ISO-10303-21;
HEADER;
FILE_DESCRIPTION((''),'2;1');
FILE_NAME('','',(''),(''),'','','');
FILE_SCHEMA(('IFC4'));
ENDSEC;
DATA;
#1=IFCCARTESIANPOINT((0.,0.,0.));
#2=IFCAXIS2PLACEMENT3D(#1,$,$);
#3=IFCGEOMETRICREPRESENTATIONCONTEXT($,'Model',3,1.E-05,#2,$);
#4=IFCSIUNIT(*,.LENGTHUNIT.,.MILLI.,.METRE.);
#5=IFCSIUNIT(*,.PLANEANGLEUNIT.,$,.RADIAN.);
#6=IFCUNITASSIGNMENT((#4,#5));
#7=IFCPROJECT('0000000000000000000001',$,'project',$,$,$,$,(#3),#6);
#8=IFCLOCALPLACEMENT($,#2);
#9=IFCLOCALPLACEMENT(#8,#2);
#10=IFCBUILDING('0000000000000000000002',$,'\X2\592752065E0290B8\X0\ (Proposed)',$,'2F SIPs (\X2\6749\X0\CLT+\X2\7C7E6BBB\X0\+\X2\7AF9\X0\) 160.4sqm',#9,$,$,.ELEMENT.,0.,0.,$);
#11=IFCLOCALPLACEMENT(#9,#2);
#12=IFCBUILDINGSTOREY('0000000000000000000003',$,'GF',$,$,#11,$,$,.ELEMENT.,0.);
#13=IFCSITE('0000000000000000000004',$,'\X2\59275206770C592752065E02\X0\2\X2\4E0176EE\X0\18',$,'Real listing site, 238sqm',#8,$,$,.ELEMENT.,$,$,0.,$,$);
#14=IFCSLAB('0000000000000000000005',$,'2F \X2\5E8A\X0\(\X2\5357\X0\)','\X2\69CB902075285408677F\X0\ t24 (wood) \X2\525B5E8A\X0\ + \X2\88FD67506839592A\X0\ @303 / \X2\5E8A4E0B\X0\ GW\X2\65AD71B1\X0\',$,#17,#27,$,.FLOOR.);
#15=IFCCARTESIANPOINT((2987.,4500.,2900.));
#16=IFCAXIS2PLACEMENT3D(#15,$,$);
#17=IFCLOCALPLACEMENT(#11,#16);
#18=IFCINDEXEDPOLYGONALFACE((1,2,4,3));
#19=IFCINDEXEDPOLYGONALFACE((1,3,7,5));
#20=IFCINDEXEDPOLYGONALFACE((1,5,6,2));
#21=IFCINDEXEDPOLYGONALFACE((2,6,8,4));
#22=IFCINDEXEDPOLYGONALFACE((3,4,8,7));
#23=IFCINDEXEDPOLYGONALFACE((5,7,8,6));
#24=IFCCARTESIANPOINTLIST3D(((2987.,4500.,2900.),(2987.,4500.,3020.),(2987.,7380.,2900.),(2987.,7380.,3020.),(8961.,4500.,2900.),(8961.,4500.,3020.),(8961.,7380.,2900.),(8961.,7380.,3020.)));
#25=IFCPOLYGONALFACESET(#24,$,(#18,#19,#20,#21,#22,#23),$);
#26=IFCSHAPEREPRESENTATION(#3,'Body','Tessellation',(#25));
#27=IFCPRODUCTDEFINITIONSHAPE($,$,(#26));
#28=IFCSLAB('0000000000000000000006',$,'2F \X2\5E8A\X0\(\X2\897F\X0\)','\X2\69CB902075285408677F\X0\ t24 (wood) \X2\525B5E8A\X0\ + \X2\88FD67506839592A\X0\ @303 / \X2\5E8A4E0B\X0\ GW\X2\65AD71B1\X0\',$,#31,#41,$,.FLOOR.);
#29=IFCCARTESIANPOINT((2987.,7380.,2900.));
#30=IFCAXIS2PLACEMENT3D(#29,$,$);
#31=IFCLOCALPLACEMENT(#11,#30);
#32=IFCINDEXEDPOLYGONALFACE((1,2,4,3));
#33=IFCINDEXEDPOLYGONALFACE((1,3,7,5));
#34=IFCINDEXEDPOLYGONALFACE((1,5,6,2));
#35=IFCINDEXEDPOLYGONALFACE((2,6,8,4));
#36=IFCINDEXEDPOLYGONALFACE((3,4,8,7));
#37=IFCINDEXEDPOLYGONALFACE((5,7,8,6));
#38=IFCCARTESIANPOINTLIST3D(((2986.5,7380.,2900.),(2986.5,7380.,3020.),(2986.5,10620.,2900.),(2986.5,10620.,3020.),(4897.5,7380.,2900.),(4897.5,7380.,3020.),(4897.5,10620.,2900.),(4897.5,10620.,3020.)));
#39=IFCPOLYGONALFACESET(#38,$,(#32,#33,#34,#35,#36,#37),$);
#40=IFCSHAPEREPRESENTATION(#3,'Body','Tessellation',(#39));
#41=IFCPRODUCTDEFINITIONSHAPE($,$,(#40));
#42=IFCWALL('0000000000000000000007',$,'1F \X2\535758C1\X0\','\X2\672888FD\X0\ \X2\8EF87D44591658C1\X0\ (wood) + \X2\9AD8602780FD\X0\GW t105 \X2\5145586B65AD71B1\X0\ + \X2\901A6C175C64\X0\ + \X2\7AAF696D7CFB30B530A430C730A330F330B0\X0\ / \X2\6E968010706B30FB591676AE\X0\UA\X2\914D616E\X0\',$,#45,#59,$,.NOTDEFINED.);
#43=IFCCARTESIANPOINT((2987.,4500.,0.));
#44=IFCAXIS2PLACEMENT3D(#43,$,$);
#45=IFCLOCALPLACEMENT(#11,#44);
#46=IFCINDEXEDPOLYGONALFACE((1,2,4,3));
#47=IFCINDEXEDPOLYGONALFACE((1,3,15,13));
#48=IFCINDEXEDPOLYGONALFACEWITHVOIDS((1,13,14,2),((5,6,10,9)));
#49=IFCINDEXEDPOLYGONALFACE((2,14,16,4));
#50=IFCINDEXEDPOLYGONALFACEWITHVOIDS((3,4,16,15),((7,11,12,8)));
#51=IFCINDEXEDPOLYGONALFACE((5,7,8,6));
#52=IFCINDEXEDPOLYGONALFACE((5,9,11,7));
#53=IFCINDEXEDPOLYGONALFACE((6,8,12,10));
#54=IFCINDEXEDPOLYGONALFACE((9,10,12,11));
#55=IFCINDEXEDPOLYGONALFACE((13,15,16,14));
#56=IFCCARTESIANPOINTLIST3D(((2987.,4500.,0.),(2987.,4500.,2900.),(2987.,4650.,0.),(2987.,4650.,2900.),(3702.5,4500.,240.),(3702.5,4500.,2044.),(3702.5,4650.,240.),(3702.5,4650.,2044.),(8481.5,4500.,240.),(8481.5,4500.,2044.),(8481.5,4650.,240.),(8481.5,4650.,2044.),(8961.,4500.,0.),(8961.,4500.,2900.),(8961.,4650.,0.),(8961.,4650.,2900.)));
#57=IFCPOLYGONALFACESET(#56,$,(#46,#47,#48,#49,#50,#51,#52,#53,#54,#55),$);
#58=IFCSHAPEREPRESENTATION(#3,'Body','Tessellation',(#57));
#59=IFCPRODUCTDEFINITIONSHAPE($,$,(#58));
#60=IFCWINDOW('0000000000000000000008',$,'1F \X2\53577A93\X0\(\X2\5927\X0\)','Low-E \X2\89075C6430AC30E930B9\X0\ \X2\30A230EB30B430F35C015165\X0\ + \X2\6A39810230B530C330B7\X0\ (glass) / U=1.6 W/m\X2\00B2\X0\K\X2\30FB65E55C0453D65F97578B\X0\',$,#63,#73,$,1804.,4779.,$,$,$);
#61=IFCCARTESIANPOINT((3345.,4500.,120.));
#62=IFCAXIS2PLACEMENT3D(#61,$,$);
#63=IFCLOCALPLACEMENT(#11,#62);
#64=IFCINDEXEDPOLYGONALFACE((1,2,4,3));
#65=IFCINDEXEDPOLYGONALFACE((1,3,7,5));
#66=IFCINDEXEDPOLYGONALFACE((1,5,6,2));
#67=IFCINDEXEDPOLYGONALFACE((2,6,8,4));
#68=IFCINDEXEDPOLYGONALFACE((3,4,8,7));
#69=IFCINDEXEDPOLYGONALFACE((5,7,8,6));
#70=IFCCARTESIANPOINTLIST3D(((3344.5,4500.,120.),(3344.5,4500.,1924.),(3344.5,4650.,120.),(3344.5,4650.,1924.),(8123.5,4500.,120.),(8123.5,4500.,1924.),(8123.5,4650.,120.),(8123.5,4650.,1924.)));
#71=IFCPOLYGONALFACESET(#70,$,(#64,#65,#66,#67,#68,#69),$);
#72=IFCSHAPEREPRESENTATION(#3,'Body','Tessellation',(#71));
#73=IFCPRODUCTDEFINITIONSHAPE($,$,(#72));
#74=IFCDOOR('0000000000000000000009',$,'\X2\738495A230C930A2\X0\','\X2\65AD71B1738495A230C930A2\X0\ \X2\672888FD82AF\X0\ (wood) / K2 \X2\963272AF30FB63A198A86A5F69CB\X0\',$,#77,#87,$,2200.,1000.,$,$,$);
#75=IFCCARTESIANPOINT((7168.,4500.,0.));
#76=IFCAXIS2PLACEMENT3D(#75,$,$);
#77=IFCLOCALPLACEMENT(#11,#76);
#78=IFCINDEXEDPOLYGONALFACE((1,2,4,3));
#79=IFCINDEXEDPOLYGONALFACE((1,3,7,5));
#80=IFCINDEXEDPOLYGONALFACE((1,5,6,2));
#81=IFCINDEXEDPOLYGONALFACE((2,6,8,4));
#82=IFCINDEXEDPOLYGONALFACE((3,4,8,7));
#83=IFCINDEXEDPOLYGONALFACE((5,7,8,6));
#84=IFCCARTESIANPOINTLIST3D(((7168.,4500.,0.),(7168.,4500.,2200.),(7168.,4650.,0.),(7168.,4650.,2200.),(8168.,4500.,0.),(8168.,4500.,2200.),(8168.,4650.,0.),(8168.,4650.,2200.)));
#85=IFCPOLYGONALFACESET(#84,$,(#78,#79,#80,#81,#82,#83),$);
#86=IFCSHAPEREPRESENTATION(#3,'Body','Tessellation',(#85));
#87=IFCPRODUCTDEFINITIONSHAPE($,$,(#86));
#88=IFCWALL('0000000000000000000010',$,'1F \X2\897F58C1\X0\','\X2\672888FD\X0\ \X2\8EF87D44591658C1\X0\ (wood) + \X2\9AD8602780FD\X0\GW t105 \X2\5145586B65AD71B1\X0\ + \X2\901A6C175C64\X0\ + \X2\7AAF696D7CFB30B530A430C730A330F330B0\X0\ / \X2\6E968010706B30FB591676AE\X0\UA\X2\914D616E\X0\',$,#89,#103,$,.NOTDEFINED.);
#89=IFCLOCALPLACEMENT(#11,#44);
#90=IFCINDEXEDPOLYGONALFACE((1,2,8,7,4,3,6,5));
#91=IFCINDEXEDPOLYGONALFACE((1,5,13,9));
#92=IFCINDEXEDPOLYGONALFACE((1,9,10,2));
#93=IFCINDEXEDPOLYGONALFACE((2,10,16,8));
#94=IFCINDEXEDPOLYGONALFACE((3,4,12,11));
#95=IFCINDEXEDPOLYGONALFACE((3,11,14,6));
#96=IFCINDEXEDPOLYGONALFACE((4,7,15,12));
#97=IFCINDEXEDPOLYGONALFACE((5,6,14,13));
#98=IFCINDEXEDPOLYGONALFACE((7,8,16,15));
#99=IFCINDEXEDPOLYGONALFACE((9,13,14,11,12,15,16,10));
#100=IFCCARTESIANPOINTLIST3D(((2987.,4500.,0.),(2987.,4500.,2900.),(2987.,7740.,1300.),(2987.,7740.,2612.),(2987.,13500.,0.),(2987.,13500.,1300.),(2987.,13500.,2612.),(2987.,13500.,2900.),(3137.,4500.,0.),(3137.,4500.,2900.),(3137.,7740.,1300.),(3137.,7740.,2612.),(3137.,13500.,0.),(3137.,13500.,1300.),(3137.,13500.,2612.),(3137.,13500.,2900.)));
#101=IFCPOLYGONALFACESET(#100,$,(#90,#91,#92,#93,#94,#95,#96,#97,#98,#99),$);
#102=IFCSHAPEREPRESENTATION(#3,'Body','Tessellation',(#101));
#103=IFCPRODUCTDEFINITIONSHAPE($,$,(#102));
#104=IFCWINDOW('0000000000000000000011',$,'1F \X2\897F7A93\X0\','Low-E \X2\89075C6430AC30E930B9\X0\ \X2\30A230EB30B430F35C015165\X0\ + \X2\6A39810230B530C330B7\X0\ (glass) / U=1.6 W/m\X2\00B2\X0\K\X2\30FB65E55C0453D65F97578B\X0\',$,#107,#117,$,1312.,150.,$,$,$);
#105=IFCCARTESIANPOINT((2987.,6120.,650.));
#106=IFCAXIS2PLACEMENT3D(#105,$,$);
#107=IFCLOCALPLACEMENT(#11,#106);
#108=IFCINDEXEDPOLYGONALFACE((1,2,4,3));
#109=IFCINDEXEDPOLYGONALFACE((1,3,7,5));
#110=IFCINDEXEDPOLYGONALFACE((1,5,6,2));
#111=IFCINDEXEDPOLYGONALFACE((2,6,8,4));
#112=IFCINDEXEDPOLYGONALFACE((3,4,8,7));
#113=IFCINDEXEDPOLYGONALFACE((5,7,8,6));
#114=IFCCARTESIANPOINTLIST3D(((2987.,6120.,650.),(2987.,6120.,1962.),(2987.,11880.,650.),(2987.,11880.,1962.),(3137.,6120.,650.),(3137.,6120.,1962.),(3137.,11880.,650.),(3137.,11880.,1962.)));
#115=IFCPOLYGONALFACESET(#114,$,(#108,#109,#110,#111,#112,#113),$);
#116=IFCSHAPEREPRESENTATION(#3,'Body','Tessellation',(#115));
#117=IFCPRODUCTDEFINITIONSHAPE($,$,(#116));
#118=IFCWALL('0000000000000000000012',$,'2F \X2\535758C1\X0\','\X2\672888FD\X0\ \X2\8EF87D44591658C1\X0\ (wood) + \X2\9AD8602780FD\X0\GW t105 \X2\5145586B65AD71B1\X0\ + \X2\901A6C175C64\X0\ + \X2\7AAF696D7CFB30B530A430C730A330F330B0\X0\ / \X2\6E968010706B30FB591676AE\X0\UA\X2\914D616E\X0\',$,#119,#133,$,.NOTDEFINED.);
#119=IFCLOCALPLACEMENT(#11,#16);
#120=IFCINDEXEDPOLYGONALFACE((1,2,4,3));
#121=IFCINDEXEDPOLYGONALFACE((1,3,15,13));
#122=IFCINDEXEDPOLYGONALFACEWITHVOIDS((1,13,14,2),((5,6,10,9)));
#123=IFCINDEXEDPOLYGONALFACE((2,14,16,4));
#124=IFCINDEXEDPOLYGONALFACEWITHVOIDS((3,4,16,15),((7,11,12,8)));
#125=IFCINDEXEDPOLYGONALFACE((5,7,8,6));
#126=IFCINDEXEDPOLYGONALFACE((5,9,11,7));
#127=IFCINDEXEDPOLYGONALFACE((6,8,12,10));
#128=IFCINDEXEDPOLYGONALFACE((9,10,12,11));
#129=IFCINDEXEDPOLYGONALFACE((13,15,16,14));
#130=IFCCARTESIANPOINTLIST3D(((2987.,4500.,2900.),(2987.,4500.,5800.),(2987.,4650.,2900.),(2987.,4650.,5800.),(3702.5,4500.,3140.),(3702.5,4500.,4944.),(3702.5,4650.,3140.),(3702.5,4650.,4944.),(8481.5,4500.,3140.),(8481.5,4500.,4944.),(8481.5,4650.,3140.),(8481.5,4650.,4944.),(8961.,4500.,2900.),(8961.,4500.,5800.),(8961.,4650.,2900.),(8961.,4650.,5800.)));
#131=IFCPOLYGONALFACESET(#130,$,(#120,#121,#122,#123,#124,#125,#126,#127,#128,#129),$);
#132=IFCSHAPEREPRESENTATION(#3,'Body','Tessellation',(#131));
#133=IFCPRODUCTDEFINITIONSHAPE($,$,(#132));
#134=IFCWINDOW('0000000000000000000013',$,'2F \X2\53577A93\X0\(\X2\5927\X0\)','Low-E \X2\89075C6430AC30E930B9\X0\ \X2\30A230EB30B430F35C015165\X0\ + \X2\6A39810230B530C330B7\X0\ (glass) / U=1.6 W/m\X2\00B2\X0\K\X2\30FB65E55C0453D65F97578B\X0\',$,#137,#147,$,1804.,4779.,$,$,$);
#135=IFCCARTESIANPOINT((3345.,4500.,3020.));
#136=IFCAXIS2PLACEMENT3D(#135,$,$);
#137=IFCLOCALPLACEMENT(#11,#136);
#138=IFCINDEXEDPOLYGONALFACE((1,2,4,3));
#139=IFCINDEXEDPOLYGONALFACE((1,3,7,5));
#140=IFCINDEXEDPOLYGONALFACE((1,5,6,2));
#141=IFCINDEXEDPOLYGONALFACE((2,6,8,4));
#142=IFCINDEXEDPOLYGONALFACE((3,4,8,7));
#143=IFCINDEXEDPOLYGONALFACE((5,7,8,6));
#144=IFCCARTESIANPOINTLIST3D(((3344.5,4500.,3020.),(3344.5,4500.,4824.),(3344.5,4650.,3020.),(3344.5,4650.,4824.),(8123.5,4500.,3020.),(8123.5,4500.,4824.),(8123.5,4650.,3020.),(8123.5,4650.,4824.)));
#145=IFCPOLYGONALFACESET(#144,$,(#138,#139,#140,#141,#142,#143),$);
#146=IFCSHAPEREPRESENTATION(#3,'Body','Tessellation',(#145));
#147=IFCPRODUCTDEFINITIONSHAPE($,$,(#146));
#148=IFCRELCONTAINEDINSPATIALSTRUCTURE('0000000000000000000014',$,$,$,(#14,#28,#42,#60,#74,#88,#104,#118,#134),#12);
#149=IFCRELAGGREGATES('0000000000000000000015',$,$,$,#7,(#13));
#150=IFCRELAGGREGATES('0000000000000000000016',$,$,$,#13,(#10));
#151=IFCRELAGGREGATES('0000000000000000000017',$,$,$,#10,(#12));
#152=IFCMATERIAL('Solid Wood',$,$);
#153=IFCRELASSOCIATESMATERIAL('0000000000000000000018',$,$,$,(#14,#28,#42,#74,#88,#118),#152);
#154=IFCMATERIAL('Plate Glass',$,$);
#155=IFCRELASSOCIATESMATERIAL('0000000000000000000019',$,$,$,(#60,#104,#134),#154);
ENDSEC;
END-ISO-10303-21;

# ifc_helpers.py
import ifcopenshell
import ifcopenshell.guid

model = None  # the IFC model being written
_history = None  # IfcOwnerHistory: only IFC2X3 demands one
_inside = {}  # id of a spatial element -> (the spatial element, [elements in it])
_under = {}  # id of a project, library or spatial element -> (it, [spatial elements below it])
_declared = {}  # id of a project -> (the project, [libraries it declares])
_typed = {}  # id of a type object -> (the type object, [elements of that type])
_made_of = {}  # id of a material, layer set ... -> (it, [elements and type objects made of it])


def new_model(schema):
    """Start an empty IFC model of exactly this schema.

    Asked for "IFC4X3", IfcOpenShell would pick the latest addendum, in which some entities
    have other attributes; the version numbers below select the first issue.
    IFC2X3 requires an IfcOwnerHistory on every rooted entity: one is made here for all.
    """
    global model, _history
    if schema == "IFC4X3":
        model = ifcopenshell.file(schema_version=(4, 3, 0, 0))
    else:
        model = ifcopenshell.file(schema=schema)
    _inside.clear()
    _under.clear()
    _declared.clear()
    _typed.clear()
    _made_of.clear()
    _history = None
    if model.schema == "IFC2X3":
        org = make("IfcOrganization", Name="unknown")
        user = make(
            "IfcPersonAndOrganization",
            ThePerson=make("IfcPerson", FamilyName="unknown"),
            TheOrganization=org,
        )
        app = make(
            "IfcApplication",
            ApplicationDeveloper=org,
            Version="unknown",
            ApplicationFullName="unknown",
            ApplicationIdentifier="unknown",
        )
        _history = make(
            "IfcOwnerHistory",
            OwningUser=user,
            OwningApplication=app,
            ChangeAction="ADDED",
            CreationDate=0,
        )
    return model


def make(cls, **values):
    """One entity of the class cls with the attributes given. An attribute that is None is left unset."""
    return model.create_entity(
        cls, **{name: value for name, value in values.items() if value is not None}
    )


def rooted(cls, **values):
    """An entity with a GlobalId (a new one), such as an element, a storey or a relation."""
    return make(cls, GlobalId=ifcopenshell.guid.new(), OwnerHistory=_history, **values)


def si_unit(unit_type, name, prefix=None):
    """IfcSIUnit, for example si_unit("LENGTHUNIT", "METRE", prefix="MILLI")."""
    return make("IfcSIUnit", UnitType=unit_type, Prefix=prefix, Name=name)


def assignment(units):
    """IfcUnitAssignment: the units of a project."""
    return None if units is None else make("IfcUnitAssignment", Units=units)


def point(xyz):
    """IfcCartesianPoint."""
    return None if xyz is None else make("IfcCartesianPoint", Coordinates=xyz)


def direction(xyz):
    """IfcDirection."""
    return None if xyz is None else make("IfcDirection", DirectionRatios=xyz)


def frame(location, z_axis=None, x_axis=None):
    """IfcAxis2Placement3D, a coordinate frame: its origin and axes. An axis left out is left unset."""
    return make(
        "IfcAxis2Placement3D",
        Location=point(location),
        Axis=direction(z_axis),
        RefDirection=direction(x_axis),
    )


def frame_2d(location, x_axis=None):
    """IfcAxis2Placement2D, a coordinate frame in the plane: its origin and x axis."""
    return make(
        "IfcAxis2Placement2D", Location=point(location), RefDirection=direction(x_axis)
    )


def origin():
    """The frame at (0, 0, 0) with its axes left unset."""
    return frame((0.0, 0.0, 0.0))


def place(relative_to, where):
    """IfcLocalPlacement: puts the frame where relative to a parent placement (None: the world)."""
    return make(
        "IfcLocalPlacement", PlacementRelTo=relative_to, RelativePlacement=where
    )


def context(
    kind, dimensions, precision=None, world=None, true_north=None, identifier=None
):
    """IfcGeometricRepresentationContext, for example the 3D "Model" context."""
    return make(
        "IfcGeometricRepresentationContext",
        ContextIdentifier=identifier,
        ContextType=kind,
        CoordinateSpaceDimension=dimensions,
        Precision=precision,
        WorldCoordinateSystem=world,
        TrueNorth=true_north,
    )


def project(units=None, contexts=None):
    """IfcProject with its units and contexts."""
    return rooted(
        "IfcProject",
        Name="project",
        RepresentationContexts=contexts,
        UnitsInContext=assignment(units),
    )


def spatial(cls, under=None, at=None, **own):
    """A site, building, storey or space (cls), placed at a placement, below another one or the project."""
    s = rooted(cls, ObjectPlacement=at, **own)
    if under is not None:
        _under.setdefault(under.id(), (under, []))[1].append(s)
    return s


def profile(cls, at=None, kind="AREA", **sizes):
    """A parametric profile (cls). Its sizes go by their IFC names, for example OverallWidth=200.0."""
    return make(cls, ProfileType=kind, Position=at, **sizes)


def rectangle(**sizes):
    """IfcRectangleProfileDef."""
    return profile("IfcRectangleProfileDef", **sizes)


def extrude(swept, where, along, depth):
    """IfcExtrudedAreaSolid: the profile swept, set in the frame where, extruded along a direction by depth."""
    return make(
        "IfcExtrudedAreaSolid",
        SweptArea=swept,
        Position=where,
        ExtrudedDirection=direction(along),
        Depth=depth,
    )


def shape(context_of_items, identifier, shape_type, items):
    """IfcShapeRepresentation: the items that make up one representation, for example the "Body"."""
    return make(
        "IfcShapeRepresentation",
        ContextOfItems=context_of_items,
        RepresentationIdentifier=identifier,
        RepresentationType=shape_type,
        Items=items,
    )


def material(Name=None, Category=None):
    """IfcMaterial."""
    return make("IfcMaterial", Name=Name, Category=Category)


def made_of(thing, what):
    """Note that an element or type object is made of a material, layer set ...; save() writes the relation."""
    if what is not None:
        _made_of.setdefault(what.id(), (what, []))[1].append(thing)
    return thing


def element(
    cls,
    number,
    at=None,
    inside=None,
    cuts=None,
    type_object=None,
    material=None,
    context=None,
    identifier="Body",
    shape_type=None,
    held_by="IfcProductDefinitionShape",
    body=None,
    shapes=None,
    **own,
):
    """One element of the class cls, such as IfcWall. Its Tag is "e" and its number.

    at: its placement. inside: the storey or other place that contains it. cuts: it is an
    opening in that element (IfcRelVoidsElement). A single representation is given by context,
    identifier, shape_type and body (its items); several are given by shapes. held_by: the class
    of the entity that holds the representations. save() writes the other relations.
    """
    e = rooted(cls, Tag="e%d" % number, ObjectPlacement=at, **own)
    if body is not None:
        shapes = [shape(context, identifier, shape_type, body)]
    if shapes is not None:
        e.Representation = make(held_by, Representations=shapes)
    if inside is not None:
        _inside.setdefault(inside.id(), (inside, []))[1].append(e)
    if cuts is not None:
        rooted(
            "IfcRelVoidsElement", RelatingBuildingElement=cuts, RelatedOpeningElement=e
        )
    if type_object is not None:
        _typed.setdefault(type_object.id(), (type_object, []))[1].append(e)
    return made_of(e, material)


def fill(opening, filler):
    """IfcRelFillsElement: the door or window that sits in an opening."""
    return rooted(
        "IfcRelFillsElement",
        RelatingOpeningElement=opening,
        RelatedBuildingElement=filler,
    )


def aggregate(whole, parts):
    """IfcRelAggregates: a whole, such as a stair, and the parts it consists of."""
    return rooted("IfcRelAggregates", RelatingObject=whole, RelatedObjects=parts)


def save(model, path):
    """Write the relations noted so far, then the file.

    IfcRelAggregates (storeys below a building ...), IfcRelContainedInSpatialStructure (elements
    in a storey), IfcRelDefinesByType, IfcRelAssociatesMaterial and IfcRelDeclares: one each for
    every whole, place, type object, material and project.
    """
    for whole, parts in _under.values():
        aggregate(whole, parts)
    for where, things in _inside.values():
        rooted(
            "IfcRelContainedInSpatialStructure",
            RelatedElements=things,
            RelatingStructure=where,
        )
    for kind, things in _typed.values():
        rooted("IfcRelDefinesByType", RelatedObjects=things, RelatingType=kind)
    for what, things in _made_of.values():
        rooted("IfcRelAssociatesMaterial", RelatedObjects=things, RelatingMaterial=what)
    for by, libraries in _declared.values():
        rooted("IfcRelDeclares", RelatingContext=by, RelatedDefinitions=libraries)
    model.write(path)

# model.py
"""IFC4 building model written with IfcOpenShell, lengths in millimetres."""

from ifc_helpers import new_model, si_unit, frame, frame_2d, origin, place, context, project, spatial, rectangle, extrude, material, element, fill, save


model = new_model("IFC4")

# Units and contexts
model_context = context("Model", 3, precision=1e-05, world=origin())
ifc_project = project(units=[si_unit("LENGTHUNIT", "METRE", prefix="MILLI"), si_unit("PLANEANGLEUNIT", "RADIAN")], contexts=[model_context])

# Site, building, storey
site_placement = place(None, origin())
site = spatial("IfcSite", under=ifc_project, at=site_placement, Name="大分県大分市2丁目18", ObjectType="Real listing site, 238sqm", CompositionType="ELEMENT", RefElevation=0.0)
building_placement = place(site_placement, origin())
building = spatial("IfcBuilding", under=site, at=building_placement, Name="大分市邸 (Proposed)", ObjectType="2F SIPs (杉CLT+籾殻+竹) 160.4sqm", CompositionType="ELEMENT", ElevationOfRefHeight=0.0, ElevationOfTerrain=0.0)
storey_placement = place(building_placement, origin())
storey = spatial("IfcBuildingStorey", under=building, at=storey_placement, Name="GF", CompositionType="ELEMENT", Elevation=0.0)

# Slabs
ifc_material_1 = material(Name="Solid Wood")
slab_1_placement = place(storey_placement, frame((2987.0, 4500.0, 2900.0)))
element("IfcSlab", 1, at=slab_1_placement, inside=storey, material=ifc_material_1, Name="2F 床(南)", Description="構造用合板 t24 (wood) 剛床 + 製材根太 @303 / 床下 GW断熱", PredefinedType="FLOOR", context=model_context, shape_type="SweptSolid", body=[
    extrude(rectangle(XDim=5974.0, YDim=2880.0, at=frame_2d((2987.0, 1440.0))), frame((2987.0, 4500.0, 2900.0)), (0.0, 0.0, 1.0), 120.0),
])
slab_2_placement = place(storey_placement, frame((2987.0, 7380.0, 2900.0)))
element("IfcSlab", 2, at=slab_2_placement, inside=storey, material=ifc_material_1, Name="2F 床(西)", Description="構造用合板 t24 (wood) 剛床 + 製材根太 @303 / 床下 GW断熱", PredefinedType="FLOOR", context=model_context, shape_type="SweptSolid", body=[
    extrude(rectangle(XDim=1911.0, YDim=3240.0, at=frame_2d((955.0, 1620.0))), frame((2987.0, 7380.0, 2900.0)), (0.0, 0.0, 1.0), 120.0),
])

# Wall, openings, window, door
wall_1_placement = place(storey_placement, frame((2987.0, 4500.0, 0.0)))
wall_1 = element("IfcWall", 3, at=wall_1_placement, inside=storey, material=ifc_material_1, Name="1F 南壁", Description="木製 軸組外壁 (wood) + 高性能GW t105 充填断熱 + 通気層 + 窯業系サイディング / 準耐火・外皮UA配慮", PredefinedType="NOTDEFINED", context=model_context, shape_type="SweptSolid", body=[
    extrude(rectangle(XDim=5974.0, YDim=150.0, at=frame_2d((2987.0, 75.0))), frame((2987.0, 4500.0, 0.0)), (0.0, 0.0, 1.0), 2900.0),
])
opening_1_placement = place(storey_placement, frame((3345.0, 4500.0, 120.0)))
opening_1 = element("IfcOpeningElement", 4, at=opening_1_placement, cuts=wall_1, PredefinedType="NOTDEFINED", context=model_context, shape_type="SweptSolid", body=[
    extrude(rectangle(XDim=4779.0, YDim=150.0, at=frame_2d((2389.0, 75.0))), frame((3345.0, 4500.0, 120.0)), (0.0, 0.0, 1.0), 1804.0),
])
opening_2_placement = place(storey_placement, frame((7168.0, 4500.0, 0.0)))
opening_2 = element("IfcOpeningElement", 5, at=opening_2_placement, cuts=wall_1, PredefinedType="NOTDEFINED", context=model_context, shape_type="SweptSolid", body=[
    extrude(rectangle(XDim=1000.0, YDim=150.0, at=frame_2d((500.0, 75.0))), frame((7168.0, 4500.0, 0.0)), (0.0, 0.0, 1.0), 2200.0),
])
ifc_material_2 = material(Name="Plate Glass")
window_1_placement = place(storey_placement, frame((3345.0, 4500.0, 120.0)))
window_1 = element("IfcWindow", 6, at=window_1_placement, inside=storey, material=ifc_material_2, Name="1F 南窓(大)", Description="Low-E 複層ガラス アルゴン封入 + 樹脂サッシ (glass) / U=1.6 W/m²K・日射取得型", OverallHeight=1804.0, OverallWidth=4779.0, context=model_context, shape_type="SweptSolid", body=[
    extrude(rectangle(XDim=4779.0, YDim=150.0, at=frame_2d((2389.0, 75.0))), frame((3345.0, 4500.0, 120.0)), (0.0, 0.0, 1.0), 1804.0),
])
fill(opening_1, window_1)
door_placement = place(storey_placement, frame((7168.0, 4500.0, 0.0)))
door = element("IfcDoor", 7, at=door_placement, inside=storey, material=ifc_material_1, Name="玄関ドア", Description="断熱玄関ドア 木製芯 (wood) / K2 防犯・採風機構", OverallHeight=2200.0, OverallWidth=1000.0, context=model_context, shape_type="SweptSolid", body=[
    extrude(rectangle(XDim=1000.0, YDim=150.0, at=frame_2d((500.0, 75.0))), frame((7168.0, 4500.0, 0.0)), (0.0, 0.0, 1.0), 2200.0),
])
fill(opening_2, door)

# Walls, openings, windows
wall_2_placement = place(storey_placement, frame((2987.0, 4500.0, 0.0)))
wall_2 = element("IfcWall", 8, at=wall_2_placement, inside=storey, material=ifc_material_1, Name="1F 西壁", Description="木製 軸組外壁 (wood) + 高性能GW t105 充填断熱 + 通気層 + 窯業系サイディング / 準耐火・外皮UA配慮", PredefinedType="NOTDEFINED", context=model_context, shape_type="SweptSolid", body=[
    extrude(rectangle(XDim=150.0, YDim=9000.0, at=frame_2d((75.0, 4500.0))), frame((2987.0, 4500.0, 0.0)), (0.0, 0.0, 1.0), 2900.0),
])
opening_3_placement = place(storey_placement, frame((2987.0, 6120.0, 650.0)))
opening_3 = element("IfcOpeningElement", 9, at=opening_3_placement, cuts=wall_2, PredefinedType="NOTDEFINED", context=model_context, shape_type="SweptSolid", body=[
    extrude(rectangle(XDim=150.0, YDim=5760.0, at=frame_2d((75.0, 2880.0))), frame((2987.0, 6120.0, 650.0)), (0.0, 0.0, 1.0), 1312.0),
])
window_2_placement = place(storey_placement, frame((2987.0, 6120.0, 650.0)))
window_2 = element("IfcWindow", 10, at=window_2_placement, inside=storey, material=ifc_material_2, Name="1F 西窓", Description="Low-E 複層ガラス アルゴン封入 + 樹脂サッシ (glass) / U=1.6 W/m²K・日射取得型", OverallHeight=1312.0, OverallWidth=150.0, context=model_context, shape_type="SweptSolid", body=[
    extrude(rectangle(XDim=150.0, YDim=5760.0, at=frame_2d((75.0, 2880.0))), frame((2987.0, 6120.0, 650.0)), (0.0, 0.0, 1.0), 1312.0),
])
fill(opening_3, window_2)
wall_3_placement = place(storey_placement, frame((2987.0, 4500.0, 2900.0)))
wall_3 = element("IfcWall", 11, at=wall_3_placement, inside=storey, material=ifc_material_1, Name="2F 南壁", Description="木製 軸組外壁 (wood) + 高性能GW t105 充填断熱 + 通気層 + 窯業系サイディング / 準耐火・外皮UA配慮", PredefinedType="NOTDEFINED", context=model_context, shape_type="SweptSolid", body=[
    extrude(rectangle(XDim=5974.0, YDim=150.0, at=frame_2d((2987.0, 75.0))), frame((2987.0, 4500.0, 2900.0)), (0.0, 0.0, 1.0), 2900.0),
])
opening_4_placement = place(storey_placement, frame((3345.0, 4500.0, 3020.0)))
opening_4 = element("IfcOpeningElement", 12, at=opening_4_placement, cuts=wall_3, PredefinedType="NOTDEFINED", context=model_context, shape_type="SweptSolid", body=[
    extrude(rectangle(XDim=4779.0, YDim=150.0, at=frame_2d((2389.0, 75.0))), frame((3345.0, 4500.0, 3020.0)), (0.0, 0.0, 1.0), 1804.0),
])
window_3_placement = place(storey_placement, frame((3345.0, 4500.0, 3020.0)))
window_3 = element("IfcWindow", 13, at=window_3_placement, inside=storey, material=ifc_material_2, Name="2F 南窓(大)", Description="Low-E 複層ガラス アルゴン封入 + 樹脂サッシ (glass) / U=1.6 W/m²K・日射取得型", OverallHeight=1804.0, OverallWidth=4779.0, context=model_context, shape_type="SweptSolid", body=[
    extrude(rectangle(XDim=4779.0, YDim=150.0, at=frame_2d((2389.0, 75.0))), frame((3345.0, 4500.0, 3020.0)), (0.0, 0.0, 1.0), 1804.0),
])
fill(opening_4, window_3)

save(model, "model.ifc")
